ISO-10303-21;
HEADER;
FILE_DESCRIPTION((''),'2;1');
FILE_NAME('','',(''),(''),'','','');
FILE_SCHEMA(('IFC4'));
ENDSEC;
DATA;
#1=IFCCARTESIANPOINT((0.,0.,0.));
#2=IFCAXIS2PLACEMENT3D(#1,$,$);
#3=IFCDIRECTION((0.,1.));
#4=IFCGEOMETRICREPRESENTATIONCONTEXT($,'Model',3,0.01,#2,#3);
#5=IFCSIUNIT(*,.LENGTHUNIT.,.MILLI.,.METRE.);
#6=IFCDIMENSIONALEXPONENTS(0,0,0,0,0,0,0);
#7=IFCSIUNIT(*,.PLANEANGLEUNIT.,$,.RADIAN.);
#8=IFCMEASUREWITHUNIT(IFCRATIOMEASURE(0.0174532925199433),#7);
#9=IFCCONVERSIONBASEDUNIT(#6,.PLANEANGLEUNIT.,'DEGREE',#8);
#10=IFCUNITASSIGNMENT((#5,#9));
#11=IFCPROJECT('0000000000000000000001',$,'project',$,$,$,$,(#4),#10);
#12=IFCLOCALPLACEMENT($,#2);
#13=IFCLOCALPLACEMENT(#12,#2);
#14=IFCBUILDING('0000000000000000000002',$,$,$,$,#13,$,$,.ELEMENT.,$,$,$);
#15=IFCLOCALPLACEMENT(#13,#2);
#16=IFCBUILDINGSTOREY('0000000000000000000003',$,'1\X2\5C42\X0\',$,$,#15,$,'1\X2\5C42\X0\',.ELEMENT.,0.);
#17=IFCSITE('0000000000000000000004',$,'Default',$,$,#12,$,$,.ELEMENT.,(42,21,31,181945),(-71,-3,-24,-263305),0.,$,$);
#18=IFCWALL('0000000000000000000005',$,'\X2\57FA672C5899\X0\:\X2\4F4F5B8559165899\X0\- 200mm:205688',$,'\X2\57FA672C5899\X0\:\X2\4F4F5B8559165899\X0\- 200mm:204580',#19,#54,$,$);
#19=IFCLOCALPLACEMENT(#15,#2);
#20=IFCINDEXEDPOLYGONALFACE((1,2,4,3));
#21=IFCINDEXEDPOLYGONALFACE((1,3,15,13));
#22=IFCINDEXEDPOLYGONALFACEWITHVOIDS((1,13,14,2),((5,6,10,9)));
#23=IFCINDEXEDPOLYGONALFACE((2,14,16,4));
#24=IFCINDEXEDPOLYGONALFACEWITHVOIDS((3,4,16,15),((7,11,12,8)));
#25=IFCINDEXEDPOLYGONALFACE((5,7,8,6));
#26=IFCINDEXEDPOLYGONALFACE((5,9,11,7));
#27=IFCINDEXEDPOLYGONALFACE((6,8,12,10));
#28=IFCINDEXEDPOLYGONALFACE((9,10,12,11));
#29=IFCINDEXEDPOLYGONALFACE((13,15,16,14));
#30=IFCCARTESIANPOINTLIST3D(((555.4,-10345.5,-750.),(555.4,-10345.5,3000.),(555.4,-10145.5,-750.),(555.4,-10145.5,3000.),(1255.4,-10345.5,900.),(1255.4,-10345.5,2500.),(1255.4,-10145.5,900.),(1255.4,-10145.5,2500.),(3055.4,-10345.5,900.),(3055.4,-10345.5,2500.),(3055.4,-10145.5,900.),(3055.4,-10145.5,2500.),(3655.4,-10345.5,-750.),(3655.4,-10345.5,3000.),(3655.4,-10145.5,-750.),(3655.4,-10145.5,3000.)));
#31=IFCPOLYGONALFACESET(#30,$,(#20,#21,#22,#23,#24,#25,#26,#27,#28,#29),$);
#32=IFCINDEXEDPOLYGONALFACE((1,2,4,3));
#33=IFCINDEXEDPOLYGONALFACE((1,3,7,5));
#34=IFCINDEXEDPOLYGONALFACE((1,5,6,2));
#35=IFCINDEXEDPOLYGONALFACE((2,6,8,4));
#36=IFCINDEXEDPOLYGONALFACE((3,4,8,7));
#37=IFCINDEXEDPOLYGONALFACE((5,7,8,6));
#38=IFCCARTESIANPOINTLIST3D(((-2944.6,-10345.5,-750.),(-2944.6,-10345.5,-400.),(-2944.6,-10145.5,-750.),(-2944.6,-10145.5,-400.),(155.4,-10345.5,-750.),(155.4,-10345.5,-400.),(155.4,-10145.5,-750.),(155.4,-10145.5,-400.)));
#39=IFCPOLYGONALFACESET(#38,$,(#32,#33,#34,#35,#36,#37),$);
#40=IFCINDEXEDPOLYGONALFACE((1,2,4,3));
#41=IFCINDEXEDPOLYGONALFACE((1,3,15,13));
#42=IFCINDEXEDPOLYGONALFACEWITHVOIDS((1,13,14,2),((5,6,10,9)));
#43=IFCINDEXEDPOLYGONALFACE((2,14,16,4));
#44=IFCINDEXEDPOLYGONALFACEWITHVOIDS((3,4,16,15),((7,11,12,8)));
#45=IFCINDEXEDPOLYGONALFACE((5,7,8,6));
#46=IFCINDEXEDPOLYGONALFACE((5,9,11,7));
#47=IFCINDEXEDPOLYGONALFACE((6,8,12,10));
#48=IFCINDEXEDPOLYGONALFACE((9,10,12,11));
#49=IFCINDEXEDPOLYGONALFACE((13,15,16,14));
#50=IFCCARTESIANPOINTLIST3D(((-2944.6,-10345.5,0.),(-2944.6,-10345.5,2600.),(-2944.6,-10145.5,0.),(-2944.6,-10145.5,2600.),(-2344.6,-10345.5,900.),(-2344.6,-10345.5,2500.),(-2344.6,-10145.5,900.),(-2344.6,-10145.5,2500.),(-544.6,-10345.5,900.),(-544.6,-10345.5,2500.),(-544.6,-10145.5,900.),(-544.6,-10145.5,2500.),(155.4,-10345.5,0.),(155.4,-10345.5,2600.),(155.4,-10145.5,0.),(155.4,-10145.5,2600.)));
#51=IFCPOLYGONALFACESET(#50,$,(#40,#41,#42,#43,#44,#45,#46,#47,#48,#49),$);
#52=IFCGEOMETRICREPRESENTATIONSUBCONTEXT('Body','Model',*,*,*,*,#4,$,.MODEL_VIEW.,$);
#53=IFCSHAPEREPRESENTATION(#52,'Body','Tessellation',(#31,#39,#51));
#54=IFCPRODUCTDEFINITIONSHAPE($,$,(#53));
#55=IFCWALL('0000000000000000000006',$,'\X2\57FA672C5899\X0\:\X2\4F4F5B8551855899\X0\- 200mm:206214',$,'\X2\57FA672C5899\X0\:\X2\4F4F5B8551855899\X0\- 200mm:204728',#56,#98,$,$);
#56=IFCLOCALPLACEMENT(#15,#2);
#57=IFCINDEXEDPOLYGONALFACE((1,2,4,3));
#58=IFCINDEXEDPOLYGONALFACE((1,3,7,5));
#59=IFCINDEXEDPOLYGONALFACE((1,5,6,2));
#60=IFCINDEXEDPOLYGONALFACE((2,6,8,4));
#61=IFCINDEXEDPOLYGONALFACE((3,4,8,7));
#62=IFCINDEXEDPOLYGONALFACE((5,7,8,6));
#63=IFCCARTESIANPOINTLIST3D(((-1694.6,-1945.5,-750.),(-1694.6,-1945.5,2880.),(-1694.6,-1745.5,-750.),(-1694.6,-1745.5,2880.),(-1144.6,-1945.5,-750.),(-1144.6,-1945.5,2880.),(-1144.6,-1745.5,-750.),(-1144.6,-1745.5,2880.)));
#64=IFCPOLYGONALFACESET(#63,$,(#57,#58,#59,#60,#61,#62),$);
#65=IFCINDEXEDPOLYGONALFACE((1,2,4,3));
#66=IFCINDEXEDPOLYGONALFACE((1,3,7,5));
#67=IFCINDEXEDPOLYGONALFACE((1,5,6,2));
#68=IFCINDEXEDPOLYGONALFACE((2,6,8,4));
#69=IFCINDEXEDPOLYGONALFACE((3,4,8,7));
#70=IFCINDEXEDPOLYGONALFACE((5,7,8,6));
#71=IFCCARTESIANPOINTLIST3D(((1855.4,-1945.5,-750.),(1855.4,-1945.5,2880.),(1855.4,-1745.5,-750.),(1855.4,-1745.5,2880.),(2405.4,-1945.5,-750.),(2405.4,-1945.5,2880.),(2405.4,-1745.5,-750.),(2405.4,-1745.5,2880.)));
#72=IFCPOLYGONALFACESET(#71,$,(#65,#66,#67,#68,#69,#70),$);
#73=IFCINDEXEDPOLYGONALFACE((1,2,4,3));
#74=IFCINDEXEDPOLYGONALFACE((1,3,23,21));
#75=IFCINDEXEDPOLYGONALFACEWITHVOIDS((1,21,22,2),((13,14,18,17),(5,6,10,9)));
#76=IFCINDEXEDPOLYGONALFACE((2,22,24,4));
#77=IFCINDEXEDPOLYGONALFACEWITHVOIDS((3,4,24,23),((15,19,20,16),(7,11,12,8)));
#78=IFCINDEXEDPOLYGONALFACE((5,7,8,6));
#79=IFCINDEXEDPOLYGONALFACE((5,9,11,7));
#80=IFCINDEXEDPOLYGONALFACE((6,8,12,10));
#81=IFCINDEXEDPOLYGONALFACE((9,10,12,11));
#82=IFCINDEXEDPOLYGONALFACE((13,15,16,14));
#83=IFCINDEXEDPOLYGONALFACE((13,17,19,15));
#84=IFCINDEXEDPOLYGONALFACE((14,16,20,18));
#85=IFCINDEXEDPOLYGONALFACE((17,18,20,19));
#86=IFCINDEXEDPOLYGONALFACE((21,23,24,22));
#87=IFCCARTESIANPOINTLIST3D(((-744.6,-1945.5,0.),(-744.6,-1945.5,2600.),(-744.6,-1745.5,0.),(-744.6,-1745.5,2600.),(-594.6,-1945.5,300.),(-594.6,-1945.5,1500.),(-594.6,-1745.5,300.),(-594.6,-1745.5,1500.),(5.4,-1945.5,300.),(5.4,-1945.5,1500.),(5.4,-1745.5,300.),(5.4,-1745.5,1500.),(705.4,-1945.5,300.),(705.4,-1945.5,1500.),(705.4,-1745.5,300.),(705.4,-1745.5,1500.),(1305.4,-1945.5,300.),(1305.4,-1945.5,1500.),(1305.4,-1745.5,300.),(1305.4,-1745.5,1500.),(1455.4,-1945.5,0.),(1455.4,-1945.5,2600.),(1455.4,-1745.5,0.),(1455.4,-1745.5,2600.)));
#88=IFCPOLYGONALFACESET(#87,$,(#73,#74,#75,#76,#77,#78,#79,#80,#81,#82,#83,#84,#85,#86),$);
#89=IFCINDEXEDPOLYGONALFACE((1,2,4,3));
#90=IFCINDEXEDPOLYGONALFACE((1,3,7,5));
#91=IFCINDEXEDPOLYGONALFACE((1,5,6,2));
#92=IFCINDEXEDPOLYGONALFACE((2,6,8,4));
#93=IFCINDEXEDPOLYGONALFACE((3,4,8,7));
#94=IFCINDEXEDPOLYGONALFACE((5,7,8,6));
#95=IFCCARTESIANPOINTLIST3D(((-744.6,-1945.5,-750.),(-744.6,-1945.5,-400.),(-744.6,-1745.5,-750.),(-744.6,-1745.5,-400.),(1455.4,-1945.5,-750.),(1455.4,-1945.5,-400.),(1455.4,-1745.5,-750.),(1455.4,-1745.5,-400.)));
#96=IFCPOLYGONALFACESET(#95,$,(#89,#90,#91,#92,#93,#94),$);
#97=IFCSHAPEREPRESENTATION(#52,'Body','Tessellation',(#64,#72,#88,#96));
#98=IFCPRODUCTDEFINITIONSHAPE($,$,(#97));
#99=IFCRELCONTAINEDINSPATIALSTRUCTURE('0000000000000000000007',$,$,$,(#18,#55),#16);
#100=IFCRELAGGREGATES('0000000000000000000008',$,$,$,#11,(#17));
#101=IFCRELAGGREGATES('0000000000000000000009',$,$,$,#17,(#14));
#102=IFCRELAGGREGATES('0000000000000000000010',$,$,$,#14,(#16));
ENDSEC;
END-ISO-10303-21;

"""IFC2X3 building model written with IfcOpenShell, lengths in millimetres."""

from ifc_helpers import new_model, entity, si_unit, converted_unit, direction, frame, frame_2d, origin, origin_2d_with_axis, place, context, subcontext, project, spatial, rectangle, extrude, element, save


model = new_model("IFC2X3")

# Units and contexts
model_context = context("Model", 3, precision=0.01, world=origin(), true_north=direction((0.0, 1.0)))
body_context = subcontext(model_context, "Body", "Model", "MODEL_VIEW")
ifc_project = project(units=[si_unit("LENGTHUNIT", "METRE", prefix="MILLI"), converted_unit("PLANEANGLEUNIT", "DEGREE", entity("IfcRatioMeasure", 0.0174532925199433), si_unit("PLANEANGLEUNIT", "RADIAN"), dimensions=[0, 0, 0, 0, 0, 0, 0])], contexts=[model_context])

# Site, building, storey
site_placement = place(None, origin())
site = spatial("IfcSite", under=ifc_project, at=site_placement, Name="Default", CompositionType="ELEMENT", RefLatitude=(42, 21, 31, 181945), RefLongitude=(-71, -3, -24, -263305), RefElevation=0.0)
building_placement = place(site_placement, origin())
building = spatial("IfcBuilding", under=site, at=building_placement, CompositionType="ELEMENT")
storey_placement = place(building_placement, origin())
storey = spatial("IfcBuildingStorey", under=building, at=storey_placement, Name="1层", LongName="1层", CompositionType="ELEMENT", Elevation=0.0)

# Walls, openings
wall_1_placement = place(storey_placement, frame((3655.4, -10245.5, -750.0), z_axis=(0.0, 0.0, 1.0), x_axis=(-1.0, 0.0, 0.0)))
wall_1 = element("IfcWall", 1, at=wall_1_placement, inside=storey, Name="基本墙:住宅外墙- 200mm:205688", ObjectType="基本墙:住宅外墙- 200mm:204580", context=body_context, shape_type="SweptSolid", body=[
    extrude(rectangle(XDim=3100.0, YDim=200.0, at=origin_2d_with_axis()), frame((1550.0, 0.0, 0.0)), (0.0, 0.0, 1.0), 3750.0),
    extrude(rectangle(XDim=3100.0, YDim=200.0, at=frame_2d((0.0, 0.0), x_axis=(1.0, 0.0))), frame((5050.0, 0.0, 0.0)), (0.0, 0.0, 1.0), 350.0),
    extrude(rectangle(XDim=200.0, YDim=3100.0, at=frame_2d((0.0, 0.0), x_axis=(1.0, 0.0))), frame((5050.0, 0.0, 750.0), z_axis=(0.0, 0.0, 1.0), x_axis=(0.0, 1.0, 0.0)), (0.0, 0.0, 1.0), 2600.0),
])
opening_1_placement = place(wall_1_placement, frame((2400.0, 100.0, 1650.0)))
element("IfcOpeningElement", 2, at=opening_1_placement, cuts=wall_1, ObjectType="Opening", context=body_context, shape_type="SweptSolid", body=[
    extrude(rectangle(XDim=1600.0, YDim=1800.0, at=frame_2d((800.0, 900.0), x_axis=(1.0, 0.0))), frame((0.0, 0.0, 0.0), z_axis=(0.0, -1.0, 0.0), x_axis=(0.0, 0.0, 1.0)), (0.0, 0.0, 1.0), 200.0),
])
opening_2_placement = place(wall_1_placement, frame((6000.0, 100.0, 1650.0)))
element("IfcOpeningElement", 3, at=opening_2_placement, cuts=wall_1, ObjectType="Opening", context=body_context, shape_type="SweptSolid", body=[
    extrude(rectangle(XDim=1600.0, YDim=1800.0, at=frame_2d((800.0, 900.0), x_axis=(1.0, 0.0))), frame((0.0, 0.0, 0.0), z_axis=(0.0, -1.0, 0.0), x_axis=(0.0, 0.0, 1.0)), (0.0, 0.0, 1.0), 200.0),
])
opening_3_placement = place(storey_placement, frame((3655.4, -10245.5, -750.0), z_axis=(0.0, 0.0, 1.0), x_axis=(-1.0, 0.0, 0.0)))
element("IfcOpeningElement", 4, at=opening_3_placement, cuts=wall_1, ObjectType="Opening", context=body_context, shape_type="SweptSolid", body=[
    extrude(rectangle(XDim=1600.0, YDim=1800.0, at=frame_2d((0.0, 0.0), x_axis=(1.0, 0.0))), frame((1500.0, -100.0, 2450.0), z_axis=(0.0, 1.0, 0.0), x_axis=(0.0, 0.0, 1.0)), (0.0, 0.0, 1.0), 200.0),
])
opening_4_placement = place(storey_placement, frame((3655.4, -10245.5, -750.0), z_axis=(0.0, 0.0, 1.0), x_axis=(-1.0, 0.0, 0.0)))
element("IfcOpeningElement", 5, at=opening_4_placement, cuts=wall_1, ObjectType="Opening", context=body_context, shape_type="SweptSolid", body=[
    extrude(rectangle(XDim=1600.0, YDim=1800.0, at=origin_2d_with_axis()), frame((5100.0, -100.0, 2450.0), z_axis=(0.0, 1.0, 0.0), x_axis=(0.0, 0.0, 1.0)), (0.0, 0.0, 1.0), 200.0),
])
wall_2_placement = place(storey_placement, frame((-1694.6, -1845.5, -750.0)))
wall_2 = element("IfcWall", 6, at=wall_2_placement, inside=storey, Name="基本墙:住宅内墙- 200mm:206214", ObjectType="基本墙:住宅内墙- 200mm:204728", context=body_context, shape_type="SweptSolid", body=[
    extrude(rectangle(XDim=550.0, YDim=200.0, at=frame_2d((0.0, 0.0), x_axis=(1.0, 0.0))), frame((275.0, 0.0, 0.0)), (0.0, 0.0, 1.0), 3630.0),
    extrude(rectangle(XDim=550.0, YDim=200.0, at=frame_2d((0.0, 0.0), x_axis=(1.0, 0.0))), frame((3825.0, 0.0, 0.0), z_axis=(0.0, 0.0, 1.0), x_axis=(-1.0, 0.0, 0.0)), (0.0, 0.0, 1.0), 3630.0),
    extrude(rectangle(XDim=200.0, YDim=2200.0, at=origin_2d_with_axis()), frame((2050.0, 0.0, 750.0), z_axis=(0.0, 0.0, 1.0), x_axis=(0.0, -1.0, 0.0)), (0.0, 0.0, 1.0), 2600.0),
    extrude(rectangle(XDim=2200.0, YDim=200.0, at=frame_2d((0.0, -33.3), x_axis=(1.0, 0.0))), frame((2050.0, -33.3, 0.0), z_axis=(0.0, 0.0, 1.0), x_axis=(-1.0, 0.0, 0.0)), (0.0, 0.0, 1.0), 350.0),
])
opening_5_placement = place(wall_2_placement, frame((1700.0, 100.0, 1050.0)))
element("IfcOpeningElement", 7, at=opening_5_placement, cuts=wall_2, ObjectType="Opening", context=body_context, shape_type="SweptSolid", body=[
    extrude(rectangle(XDim=1200.0, YDim=600.0, at=frame_2d((600.0, 300.0), x_axis=(-1.0, 0.0))), frame((0.0, 0.0, 0.0), z_axis=(0.0, -1.0, 0.0), x_axis=(0.0, 0.0, 1.0)), (0.0, 0.0, 1.0), 200.0),
])
opening_6_placement = place(wall_2_placement, frame((3000.0, 100.0, 1050.0)))
element("IfcOpeningElement", 8, at=opening_6_placement, cuts=wall_2, ObjectType="Opening", context=body_context, shape_type="SweptSolid", body=[
    extrude(rectangle(XDim=1200.0, YDim=600.0, at=frame_2d((600.0, 300.0), x_axis=(-1.0, 0.0))), frame((0.0, 0.0, 0.0), z_axis=(0.0, -1.0, 0.0), x_axis=(0.0, 0.0, 1.0)), (0.0, 0.0, 1.0), 200.0),
])
opening_7_placement = place(storey_placement, frame((-1694.6, -1845.5, -750.0)))
element("IfcOpeningElement", 9, at=opening_7_placement, cuts=wall_2, ObjectType="Opening", context=body_context, shape_type="SweptSolid", body=[
    extrude(rectangle(XDim=1200.0, YDim=600.0, at=origin_2d_with_axis()), frame((1400.0, 100.0, 1650.0), z_axis=(0.0, -1.0, 0.0), x_axis=(0.0, 0.0, -1.0)), (0.0, 0.0, 1.0), 200.0),
])
opening_8_placement = place(storey_placement, frame((-1694.6, -1845.5, -750.0)))
element("IfcOpeningElement", 10, at=opening_8_placement, cuts=wall_2, ObjectType="Opening", context=body_context, shape_type="SweptSolid", body=[
    extrude(rectangle(XDim=1200.0, YDim=600.0, at=frame_2d((0.0, 0.0), x_axis=(1.0, 0.0))), frame((2700.0, 100.0, 1650.0), z_axis=(0.0, -1.0, 0.0), x_axis=(0.0, 0.0, -1.0)), (0.0, 0.0, 1.0), 200.0),
])

save(model, "model.ifc")
